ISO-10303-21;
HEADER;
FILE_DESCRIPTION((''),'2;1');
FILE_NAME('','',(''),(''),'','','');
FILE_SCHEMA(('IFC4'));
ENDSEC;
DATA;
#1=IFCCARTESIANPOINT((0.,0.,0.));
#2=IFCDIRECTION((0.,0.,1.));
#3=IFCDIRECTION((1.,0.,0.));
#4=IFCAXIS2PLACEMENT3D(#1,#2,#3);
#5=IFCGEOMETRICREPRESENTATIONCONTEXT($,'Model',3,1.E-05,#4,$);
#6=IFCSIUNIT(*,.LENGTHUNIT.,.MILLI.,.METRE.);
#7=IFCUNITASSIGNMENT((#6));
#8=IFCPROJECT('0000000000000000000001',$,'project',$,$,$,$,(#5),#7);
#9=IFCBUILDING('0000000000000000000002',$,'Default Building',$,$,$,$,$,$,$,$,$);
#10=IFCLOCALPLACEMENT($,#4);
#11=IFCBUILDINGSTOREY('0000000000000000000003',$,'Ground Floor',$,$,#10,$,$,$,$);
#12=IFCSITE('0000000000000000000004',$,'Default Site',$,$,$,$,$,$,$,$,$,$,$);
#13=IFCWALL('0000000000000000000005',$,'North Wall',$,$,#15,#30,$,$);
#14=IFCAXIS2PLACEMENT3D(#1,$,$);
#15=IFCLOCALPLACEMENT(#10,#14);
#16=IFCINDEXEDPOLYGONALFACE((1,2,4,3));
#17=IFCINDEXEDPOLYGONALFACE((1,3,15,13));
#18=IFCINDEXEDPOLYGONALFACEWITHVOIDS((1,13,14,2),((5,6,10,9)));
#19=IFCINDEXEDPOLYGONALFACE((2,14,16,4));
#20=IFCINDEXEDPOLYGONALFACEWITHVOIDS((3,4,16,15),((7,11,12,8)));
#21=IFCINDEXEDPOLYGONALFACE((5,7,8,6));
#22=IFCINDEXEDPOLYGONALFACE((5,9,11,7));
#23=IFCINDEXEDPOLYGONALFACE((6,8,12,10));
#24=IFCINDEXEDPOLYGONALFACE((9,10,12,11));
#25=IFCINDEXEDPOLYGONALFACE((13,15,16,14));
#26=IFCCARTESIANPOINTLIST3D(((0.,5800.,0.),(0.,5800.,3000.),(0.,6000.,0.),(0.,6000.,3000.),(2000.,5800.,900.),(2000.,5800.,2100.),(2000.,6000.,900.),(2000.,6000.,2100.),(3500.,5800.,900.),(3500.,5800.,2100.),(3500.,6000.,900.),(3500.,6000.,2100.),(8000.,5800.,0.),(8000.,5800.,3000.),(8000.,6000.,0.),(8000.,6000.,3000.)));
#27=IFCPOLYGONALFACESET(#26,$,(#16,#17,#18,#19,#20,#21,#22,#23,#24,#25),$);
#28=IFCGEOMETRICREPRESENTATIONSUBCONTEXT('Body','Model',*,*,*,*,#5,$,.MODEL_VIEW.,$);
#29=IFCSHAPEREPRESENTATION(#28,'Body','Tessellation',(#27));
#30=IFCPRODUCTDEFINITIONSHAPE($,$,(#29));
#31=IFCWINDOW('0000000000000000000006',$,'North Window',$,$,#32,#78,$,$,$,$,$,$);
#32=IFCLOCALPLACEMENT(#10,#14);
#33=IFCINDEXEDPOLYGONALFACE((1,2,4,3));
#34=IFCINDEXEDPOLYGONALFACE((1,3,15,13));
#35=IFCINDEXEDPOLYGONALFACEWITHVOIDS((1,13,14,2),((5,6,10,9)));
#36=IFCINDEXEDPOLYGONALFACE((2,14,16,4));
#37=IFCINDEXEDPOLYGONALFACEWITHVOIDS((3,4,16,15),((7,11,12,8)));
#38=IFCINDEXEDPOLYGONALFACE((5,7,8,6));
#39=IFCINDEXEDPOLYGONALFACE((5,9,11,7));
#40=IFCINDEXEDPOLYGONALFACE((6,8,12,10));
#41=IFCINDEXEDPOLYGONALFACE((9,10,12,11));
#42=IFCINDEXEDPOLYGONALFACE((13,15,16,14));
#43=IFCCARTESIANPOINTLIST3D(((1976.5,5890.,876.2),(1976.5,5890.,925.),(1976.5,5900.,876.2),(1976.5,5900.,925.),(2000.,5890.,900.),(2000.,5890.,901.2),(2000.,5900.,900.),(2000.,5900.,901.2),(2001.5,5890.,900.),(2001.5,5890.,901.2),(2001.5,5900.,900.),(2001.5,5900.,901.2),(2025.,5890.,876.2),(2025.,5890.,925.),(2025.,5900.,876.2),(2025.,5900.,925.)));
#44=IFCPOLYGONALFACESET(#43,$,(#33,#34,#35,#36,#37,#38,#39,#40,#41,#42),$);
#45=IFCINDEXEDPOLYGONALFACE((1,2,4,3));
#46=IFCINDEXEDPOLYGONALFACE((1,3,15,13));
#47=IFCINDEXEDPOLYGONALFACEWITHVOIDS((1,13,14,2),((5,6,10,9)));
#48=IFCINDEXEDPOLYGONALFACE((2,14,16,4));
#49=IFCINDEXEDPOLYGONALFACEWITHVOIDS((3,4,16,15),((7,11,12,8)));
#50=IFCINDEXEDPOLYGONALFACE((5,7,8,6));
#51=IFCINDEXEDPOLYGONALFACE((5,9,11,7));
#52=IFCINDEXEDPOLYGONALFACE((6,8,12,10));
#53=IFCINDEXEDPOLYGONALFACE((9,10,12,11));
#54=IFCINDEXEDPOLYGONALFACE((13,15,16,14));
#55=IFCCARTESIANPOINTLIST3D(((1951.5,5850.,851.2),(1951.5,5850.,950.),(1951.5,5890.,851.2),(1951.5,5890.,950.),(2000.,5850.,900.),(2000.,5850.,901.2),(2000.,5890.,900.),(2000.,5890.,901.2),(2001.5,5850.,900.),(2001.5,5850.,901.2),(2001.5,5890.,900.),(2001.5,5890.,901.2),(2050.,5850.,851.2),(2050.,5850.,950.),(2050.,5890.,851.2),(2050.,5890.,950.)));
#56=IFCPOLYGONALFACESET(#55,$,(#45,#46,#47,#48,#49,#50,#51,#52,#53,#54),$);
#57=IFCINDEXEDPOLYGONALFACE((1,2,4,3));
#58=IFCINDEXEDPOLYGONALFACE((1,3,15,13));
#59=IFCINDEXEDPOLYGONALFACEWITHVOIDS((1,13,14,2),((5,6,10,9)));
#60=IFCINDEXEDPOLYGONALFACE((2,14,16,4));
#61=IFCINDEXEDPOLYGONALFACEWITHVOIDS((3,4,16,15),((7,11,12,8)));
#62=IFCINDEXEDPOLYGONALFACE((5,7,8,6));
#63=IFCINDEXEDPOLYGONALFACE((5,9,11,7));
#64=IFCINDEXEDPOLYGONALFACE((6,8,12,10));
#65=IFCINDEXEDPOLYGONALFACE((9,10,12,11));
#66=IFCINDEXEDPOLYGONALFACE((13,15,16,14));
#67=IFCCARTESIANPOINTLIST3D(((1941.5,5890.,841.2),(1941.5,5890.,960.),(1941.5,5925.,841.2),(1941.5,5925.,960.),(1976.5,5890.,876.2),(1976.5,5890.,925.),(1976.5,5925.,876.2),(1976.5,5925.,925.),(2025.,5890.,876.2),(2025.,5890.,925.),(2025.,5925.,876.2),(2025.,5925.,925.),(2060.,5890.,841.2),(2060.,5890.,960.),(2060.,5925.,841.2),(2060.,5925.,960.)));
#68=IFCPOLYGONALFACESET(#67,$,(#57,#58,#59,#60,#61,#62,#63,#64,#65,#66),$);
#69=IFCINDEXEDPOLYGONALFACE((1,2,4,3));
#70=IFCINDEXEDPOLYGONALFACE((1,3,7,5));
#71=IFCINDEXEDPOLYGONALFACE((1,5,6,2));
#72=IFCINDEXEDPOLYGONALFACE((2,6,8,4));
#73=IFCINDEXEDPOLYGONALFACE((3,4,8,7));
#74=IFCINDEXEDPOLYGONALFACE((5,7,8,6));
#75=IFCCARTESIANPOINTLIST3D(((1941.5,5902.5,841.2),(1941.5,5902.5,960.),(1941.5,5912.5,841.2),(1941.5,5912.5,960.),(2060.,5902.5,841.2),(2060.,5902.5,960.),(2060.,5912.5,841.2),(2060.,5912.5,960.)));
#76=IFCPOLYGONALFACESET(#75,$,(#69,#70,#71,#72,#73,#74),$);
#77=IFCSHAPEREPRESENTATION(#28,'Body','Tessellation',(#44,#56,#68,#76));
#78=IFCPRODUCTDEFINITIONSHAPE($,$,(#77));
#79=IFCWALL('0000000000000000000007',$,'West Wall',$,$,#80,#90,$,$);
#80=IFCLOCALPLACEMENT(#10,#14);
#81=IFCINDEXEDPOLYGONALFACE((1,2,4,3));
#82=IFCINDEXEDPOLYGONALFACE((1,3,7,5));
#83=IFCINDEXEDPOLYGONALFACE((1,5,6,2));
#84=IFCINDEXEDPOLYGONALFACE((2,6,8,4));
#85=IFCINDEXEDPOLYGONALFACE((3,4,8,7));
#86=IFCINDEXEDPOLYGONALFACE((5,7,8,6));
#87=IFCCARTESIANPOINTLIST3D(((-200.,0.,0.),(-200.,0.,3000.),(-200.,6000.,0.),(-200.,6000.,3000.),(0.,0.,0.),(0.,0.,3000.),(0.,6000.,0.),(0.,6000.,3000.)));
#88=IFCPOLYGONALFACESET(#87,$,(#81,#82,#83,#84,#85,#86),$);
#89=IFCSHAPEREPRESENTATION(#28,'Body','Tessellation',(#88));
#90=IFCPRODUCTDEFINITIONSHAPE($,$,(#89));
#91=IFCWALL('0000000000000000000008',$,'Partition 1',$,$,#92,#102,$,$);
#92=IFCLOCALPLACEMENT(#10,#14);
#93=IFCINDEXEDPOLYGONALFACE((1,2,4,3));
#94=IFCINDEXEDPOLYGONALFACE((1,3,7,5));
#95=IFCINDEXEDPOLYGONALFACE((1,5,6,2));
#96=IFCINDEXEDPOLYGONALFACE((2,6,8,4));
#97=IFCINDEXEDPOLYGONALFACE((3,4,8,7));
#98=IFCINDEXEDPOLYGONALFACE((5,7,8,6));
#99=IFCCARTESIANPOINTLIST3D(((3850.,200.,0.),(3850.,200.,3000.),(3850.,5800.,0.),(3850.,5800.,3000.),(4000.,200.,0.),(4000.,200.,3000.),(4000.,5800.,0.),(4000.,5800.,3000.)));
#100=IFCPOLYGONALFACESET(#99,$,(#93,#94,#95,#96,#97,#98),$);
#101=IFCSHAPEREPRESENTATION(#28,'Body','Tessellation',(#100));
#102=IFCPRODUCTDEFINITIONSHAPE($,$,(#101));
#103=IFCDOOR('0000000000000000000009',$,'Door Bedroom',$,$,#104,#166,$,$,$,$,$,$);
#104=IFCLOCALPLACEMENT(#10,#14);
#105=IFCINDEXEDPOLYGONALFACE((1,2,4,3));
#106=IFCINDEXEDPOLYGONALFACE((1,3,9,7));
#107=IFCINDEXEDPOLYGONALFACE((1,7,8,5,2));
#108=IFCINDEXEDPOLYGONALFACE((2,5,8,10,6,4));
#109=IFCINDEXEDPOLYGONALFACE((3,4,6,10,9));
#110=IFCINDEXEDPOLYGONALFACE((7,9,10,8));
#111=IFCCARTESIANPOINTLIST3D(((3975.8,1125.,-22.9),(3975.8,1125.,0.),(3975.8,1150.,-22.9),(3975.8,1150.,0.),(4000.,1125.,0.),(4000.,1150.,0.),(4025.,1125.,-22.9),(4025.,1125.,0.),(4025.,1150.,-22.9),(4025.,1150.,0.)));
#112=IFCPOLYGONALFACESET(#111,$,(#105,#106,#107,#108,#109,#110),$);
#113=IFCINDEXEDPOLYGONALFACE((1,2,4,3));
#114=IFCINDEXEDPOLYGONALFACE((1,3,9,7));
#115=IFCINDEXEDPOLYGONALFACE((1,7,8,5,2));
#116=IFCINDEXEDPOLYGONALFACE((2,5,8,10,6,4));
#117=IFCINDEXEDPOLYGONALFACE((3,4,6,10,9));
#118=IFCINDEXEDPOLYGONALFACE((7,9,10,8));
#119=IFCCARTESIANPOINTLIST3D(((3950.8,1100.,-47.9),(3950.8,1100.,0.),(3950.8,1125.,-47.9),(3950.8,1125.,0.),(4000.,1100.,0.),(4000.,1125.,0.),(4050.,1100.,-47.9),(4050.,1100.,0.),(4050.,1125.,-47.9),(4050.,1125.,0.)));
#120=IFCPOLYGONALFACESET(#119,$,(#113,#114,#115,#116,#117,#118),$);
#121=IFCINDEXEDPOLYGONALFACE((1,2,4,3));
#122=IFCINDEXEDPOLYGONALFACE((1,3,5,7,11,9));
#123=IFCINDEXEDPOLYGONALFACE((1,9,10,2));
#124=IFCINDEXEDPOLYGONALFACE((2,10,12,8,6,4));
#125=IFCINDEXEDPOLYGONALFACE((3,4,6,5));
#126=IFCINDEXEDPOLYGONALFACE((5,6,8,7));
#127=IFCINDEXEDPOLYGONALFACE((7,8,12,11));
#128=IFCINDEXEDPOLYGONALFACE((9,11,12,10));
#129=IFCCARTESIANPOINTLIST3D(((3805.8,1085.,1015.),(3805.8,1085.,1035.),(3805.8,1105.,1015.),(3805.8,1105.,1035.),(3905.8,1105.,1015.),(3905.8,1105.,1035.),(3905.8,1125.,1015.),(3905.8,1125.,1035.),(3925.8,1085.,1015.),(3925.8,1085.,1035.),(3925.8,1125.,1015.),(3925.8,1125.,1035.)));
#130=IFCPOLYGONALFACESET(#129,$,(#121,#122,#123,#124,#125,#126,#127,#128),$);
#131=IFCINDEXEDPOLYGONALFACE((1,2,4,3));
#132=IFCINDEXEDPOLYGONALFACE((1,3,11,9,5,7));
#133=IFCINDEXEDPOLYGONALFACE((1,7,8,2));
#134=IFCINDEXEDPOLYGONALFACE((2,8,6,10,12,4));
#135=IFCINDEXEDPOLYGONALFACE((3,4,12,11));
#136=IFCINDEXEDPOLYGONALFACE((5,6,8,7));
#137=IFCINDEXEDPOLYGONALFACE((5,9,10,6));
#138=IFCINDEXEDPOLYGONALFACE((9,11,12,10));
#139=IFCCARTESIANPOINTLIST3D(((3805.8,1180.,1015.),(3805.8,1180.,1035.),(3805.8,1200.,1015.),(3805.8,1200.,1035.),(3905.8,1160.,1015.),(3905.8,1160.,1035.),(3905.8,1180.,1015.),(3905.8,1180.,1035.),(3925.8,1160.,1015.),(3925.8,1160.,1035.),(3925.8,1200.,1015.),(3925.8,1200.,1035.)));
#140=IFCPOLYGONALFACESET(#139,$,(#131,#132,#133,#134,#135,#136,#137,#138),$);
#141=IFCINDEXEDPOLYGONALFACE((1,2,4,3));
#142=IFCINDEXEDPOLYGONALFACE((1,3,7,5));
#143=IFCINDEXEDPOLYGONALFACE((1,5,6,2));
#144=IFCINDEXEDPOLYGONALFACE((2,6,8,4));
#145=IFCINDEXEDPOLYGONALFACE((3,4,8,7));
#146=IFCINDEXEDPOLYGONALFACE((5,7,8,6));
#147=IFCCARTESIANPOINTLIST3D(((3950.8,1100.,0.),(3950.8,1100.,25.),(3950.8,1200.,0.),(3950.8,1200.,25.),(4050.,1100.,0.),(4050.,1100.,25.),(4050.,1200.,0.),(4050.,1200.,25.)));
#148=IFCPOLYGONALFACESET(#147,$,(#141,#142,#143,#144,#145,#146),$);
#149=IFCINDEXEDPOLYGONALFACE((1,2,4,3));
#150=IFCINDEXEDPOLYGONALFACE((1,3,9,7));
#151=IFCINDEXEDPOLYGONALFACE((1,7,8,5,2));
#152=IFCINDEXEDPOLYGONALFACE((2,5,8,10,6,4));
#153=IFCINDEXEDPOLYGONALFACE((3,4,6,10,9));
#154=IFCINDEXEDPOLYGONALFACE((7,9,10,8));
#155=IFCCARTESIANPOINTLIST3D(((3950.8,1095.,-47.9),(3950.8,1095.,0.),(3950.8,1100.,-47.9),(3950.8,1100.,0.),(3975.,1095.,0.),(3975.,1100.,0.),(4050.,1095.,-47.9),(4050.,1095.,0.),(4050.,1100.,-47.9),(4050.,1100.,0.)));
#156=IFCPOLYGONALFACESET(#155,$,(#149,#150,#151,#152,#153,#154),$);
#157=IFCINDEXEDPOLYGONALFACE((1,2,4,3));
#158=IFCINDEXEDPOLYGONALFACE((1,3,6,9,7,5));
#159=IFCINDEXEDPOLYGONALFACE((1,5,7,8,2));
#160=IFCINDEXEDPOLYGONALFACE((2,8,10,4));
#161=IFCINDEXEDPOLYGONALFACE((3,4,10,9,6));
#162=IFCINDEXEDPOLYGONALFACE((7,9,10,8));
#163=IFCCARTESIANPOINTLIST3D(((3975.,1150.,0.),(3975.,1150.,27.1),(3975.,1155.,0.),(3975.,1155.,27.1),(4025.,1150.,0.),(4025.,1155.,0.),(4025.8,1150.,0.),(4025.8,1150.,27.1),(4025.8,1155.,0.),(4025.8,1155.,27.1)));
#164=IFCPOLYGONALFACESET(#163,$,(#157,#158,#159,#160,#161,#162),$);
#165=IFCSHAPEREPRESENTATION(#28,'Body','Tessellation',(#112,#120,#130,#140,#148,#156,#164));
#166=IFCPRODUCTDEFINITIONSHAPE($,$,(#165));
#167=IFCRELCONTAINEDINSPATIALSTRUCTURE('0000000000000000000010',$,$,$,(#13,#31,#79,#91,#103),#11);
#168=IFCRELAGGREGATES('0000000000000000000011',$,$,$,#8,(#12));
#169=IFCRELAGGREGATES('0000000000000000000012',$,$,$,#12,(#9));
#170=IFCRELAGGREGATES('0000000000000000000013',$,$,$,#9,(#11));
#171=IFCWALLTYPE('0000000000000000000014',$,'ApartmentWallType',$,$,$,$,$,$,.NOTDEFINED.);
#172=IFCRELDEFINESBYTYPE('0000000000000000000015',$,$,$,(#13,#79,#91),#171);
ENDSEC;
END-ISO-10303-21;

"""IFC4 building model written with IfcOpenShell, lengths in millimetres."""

from ifc_helpers import new_model, si_unit, frame, origin_with_axes, place, context, subcontext, project, spatial, line, indexed_curve, outline, extrude, type_object, element, fill, save


model = new_model("IFC4")

# Units and contexts
model_context = context("Model", 3, precision=1e-05, world=origin_with_axes())
body_context = subcontext(model_context, "Body", "Model", "MODEL_VIEW")
ifc_project = project(units=[si_unit("LENGTHUNIT", "METRE", prefix="MILLI")], contexts=[model_context])

# Site, building, storey
site = spatial("IfcSite", under=ifc_project, Name="Default Site")
building = spatial("IfcBuilding", under=site, Name="Default Building")
storey_placement = place(None, origin_with_axes())
storey = spatial("IfcBuildingStorey", under=building, at=storey_placement, Name="Ground Floor")

# Shared definitions
wall_type = type_object("IfcWallType", Name="ApartmentWallType", PredefinedType="NOTDEFINED")

# Wall, opening, window
wall_1_placement = place(storey_placement, origin_with_axes())
wall_1 = element("IfcWall", 1, at=wall_1_placement, inside=storey, type_object=wall_type, Name="North Wall", context=body_context, shape_type="SweptSolid", body=[
    extrude(outline(indexed_curve([(0.0, 5800.0), (8000.0, 5800.0), (8000.0, 6000.0), (0.0, 6000.0), (0.0, 5800.0)])), None, (0.0, 0.0, 1.0), 3000.0),
])
opening_1_placement = place(wall_1_placement, frame((0.0, 0.0, 900.0), z_axis=(0.0, 0.0, 1.0), x_axis=(1.0, 0.0, 0.0)))
opening_1 = element("IfcOpeningElement", 2, at=opening_1_placement, cuts=wall_1, context=body_context, shape_type="SweptSolid", body=[
    extrude(outline(indexed_curve([(2000.0, 5800.0), (3500.0, 5800.0), (3500.0, 6000.0), (2000.0, 6000.0), (2000.0, 5800.0)])), None, (0.0, 0.0, 1.0), 1200.0),
])
window_1_placement = place(storey_placement, frame((2000.0, 5800.0, 900.0), z_axis=(0.0, 0.0, 1.0), x_axis=(1.0, 0.0, 0.0)))
window_1 = element("IfcWindow", 3, at=window_1_placement, inside=storey, Name="North Window", context=body_context, shape_type="SweptSolid", body=[
    extrude(outline(indexed_curve([(0.0, 0.0), (1.5, 0.0), (1.5, 1.2), (0.0, 1.2)], segments=[line(1, 2, 3, 4, 1)]), holes=[indexed_curve([(25.0, 25.0), (-23.5, 25.0), (-23.5, -23.8), (25.0, -23.8)], segments=[line(1, 2, 3, 4, 1)])]), frame((0.0, 90.0, 0.0), z_axis=(0.0, -1.0, 0.0), x_axis=(1.0, 0.0, 0.0)), (0.0, 0.0, -1.0), 10.0),
    extrude(outline(indexed_curve([(0.0, 0.0), (1.5, 0.0), (1.5, 1.2), (0.0, 1.2)], segments=[line(1, 2, 3, 4, 1)]), holes=[indexed_curve([(50.0, 50.0), (-48.5, 50.0), (-48.5, -48.8), (50.0, -48.8)], segments=[line(1, 2, 3, 4, 1)])]), frame((0.0, 50.0, 0.0), z_axis=(0.0, -1.0, 0.0), x_axis=(1.0, 0.0, 0.0)), (0.0, 0.0, -1.0), 40.0),
    extrude(outline(indexed_curve([(0.0, 0.0), (-48.5, 0.0), (-48.5, -48.8), (0.0, -48.8)], segments=[line(1, 2, 3, 4, 1)]), holes=[indexed_curve([(35.0, 35.0), (-83.5, 35.0), (-83.5, -83.8), (35.0, -83.8)], segments=[line(1, 2, 3, 4, 1)])]), frame((25.0, 90.0, 25.0), z_axis=(0.0, -1.0, 0.0), x_axis=(1.0, 0.0, 0.0)), (0.0, 0.0, -1.0), 35.0),
    extrude(outline(indexed_curve([(35.0, 35.0), (-83.5, 35.0), (-83.5, -83.8), (35.0, -83.8)], segments=[line(1, 2, 3, 4, 1)])), frame((25.0, 102.5, 25.0), z_axis=(0.0, -1.0, 0.0), x_axis=(1.0, 0.0, 0.0)), (0.0, 0.0, -1.0), 10.0),
])
fill(opening_1, window_1)

# Wall
wall_2_placement = place(storey_placement, origin_with_axes())
element("IfcWall", 4, at=wall_2_placement, inside=storey, type_object=wall_type, Name="West Wall", context=body_context, shape_type="SweptSolid", body=[
    extrude(outline(indexed_curve([(0.0, 0.0), (0.0, 6000.0), (-200.0, 6000.0), (-200.0, 0.0), (0.0, 0.0)])), None, (0.0, 0.0, 1.0), 3000.0),
])

# Wall, opening, door
wall_3_placement = place(storey_placement, origin_with_axes())
wall_3 = element("IfcWall", 5, at=wall_3_placement, inside=storey, type_object=wall_type, Name="Partition 1", context=body_context, shape_type="SweptSolid", body=[
    extrude(outline(indexed_curve([(4000.0, 200.0), (4000.0, 5800.0), (3850.0, 5800.0), (3850.0, 200.0), (4000.0, 200.0)])), None, (0.0, 0.0, 1.0), 3000.0),
])
opening_2_placement = place(wall_3_placement, origin_with_axes())
opening_2 = element("IfcOpeningElement", 6, at=opening_2_placement, cuts=wall_3, context=body_context, shape_type="SweptSolid", body=[
    extrude(outline(indexed_curve([(4000.0, 1100.0), (4800.0, 1100.0), (4800.0, 1250.0), (4000.0, 1250.0), (4000.0, 1100.0)])), None, (0.0, 0.0, 1.0), 2100.0),
])
door_1_placement = place(storey_placement, frame((4000.0, 1100.0, 0.0), z_axis=(0.0, 0.0, 1.0), x_axis=(1.0, 0.0, 0.0)))
door_1 = element("IfcDoor", 7, at=door_1_placement, inside=storey, Name="Door Bedroom", context=body_context, shape_type="SweptSolid", body=[
    extrude(outline(indexed_curve([(0.0, 0.0), (0.0, 2.1), (0.8, 2.1), (0.8, 0.0), (-24.2, 0.0), (-24.2, -22.9), (25.0, -22.9), (25.0, 0.0)], segments=[line(1, 2, 3, 4, 5, 6, 7, 8, 1)])), frame((0.0, 25.0, 0.0), z_axis=(0.0, -1.0, 0.0), x_axis=(1.0, 0.0, 0.0)), (0.0, 0.0, -1.0), 25.0),
    extrude(outline(indexed_curve([(0.0, 0.0), (0.0, 2.1), (0.8, 2.1), (0.8, 0.0), (-49.2, 0.0), (-49.2, -47.9), (50.0, -47.9), (50.0, 0.0)], segments=[line(1, 2, 3, 4, 5, 6, 7, 8, 1)])), frame((0.0, 0.0, 0.0), z_axis=(0.0, -1.0, 0.0), x_axis=(1.0, 0.0, 0.0)), (0.0, 0.0, -1.0), 25.0),
    extrude(outline(indexed_curve([(0.0, 0.0), (-49.2, 0.0), (-49.2, 35.0), (0.0, 35.0)], segments=[line(1, 2, 3, 4, 1)])), frame((25.0, 25.0, 25.0), z_axis=(0.0, 0.0, 1.0), x_axis=(1.0, 0.0, 0.0)), (0.0, 0.0, 1.0), -47.9),
    extrude(outline(indexed_curve([(0.0, 0.0), (0.0, -40.0), (-120.0, -40.0), (-120.0, -20.0), (-20.0, -20.0), (-20.0, 0.0)], segments=[line(1, 2, 3, 4, 5, 6, 1)])), frame((-74.2, 25.0, 1015.0), z_axis=(0.0, 0.0, 1.0), x_axis=(1.0, 0.0, 0.0)), (0.0, 0.0, 1.0), 20.0),
    extrude(outline(indexed_curve([(0.0, 0.0), (0.0, 40.0), (-120.0, 40.0), (-120.0, 20.0), (-20.0, 20.0), (-20.0, 0.0)], segments=[line(1, 2, 3, 4, 5, 6, 1)])), frame((-74.2, 60.0, 1015.0), z_axis=(0.0, 0.0, 1.0), x_axis=(1.0, 0.0, 0.0)), (0.0, 0.0, 1.0), 20.0),
    extrude(outline(indexed_curve([(0.0, 0.0), (-99.2, 0.0), (-99.2, 100.0), (0.0, 100.0)], segments=[line(1, 2, 3, 4, 1)])), frame((50.0, 0.0, 0.0), z_axis=(0.0, 0.0, 1.0), x_axis=(1.0, 0.0, 0.0)), (0.0, 0.0, 1.0), 25.0),
    extrude(outline(indexed_curve([(0.0, 0.0), (0.0, 27.1), (50.8, 27.1), (50.8, 0.0), (-24.2, 0.0), (-24.2, -47.9), (75.0, -47.9), (75.0, 0.0)], segments=[line(1, 2, 3, 4, 5, 6, 7, 8, 1)])), frame((-25.0, -5.0, 0.0), z_axis=(0.0, -1.0, 0.0), x_axis=(1.0, 0.0, 0.0)), (0.0, 0.0, -1.0), 5.0),
    extrude(outline(indexed_curve([(0.0, 0.0), (0.0, 27.1), (50.8, 27.1), (50.8, 0.0), (0.8, 0.0), (0.8, -22.9), (50.0, -22.9), (50.0, 0.0)], segments=[line(1, 2, 3, 4, 5, 6, 7, 8, 1)])), frame((-25.0, 50.0, 0.0), z_axis=(0.0, -1.0, 0.0), x_axis=(1.0, 0.0, 0.0)), (0.0, 0.0, -1.0), 5.0),
])
fill(opening_2, door_1)

save(model, "model.ifc")
